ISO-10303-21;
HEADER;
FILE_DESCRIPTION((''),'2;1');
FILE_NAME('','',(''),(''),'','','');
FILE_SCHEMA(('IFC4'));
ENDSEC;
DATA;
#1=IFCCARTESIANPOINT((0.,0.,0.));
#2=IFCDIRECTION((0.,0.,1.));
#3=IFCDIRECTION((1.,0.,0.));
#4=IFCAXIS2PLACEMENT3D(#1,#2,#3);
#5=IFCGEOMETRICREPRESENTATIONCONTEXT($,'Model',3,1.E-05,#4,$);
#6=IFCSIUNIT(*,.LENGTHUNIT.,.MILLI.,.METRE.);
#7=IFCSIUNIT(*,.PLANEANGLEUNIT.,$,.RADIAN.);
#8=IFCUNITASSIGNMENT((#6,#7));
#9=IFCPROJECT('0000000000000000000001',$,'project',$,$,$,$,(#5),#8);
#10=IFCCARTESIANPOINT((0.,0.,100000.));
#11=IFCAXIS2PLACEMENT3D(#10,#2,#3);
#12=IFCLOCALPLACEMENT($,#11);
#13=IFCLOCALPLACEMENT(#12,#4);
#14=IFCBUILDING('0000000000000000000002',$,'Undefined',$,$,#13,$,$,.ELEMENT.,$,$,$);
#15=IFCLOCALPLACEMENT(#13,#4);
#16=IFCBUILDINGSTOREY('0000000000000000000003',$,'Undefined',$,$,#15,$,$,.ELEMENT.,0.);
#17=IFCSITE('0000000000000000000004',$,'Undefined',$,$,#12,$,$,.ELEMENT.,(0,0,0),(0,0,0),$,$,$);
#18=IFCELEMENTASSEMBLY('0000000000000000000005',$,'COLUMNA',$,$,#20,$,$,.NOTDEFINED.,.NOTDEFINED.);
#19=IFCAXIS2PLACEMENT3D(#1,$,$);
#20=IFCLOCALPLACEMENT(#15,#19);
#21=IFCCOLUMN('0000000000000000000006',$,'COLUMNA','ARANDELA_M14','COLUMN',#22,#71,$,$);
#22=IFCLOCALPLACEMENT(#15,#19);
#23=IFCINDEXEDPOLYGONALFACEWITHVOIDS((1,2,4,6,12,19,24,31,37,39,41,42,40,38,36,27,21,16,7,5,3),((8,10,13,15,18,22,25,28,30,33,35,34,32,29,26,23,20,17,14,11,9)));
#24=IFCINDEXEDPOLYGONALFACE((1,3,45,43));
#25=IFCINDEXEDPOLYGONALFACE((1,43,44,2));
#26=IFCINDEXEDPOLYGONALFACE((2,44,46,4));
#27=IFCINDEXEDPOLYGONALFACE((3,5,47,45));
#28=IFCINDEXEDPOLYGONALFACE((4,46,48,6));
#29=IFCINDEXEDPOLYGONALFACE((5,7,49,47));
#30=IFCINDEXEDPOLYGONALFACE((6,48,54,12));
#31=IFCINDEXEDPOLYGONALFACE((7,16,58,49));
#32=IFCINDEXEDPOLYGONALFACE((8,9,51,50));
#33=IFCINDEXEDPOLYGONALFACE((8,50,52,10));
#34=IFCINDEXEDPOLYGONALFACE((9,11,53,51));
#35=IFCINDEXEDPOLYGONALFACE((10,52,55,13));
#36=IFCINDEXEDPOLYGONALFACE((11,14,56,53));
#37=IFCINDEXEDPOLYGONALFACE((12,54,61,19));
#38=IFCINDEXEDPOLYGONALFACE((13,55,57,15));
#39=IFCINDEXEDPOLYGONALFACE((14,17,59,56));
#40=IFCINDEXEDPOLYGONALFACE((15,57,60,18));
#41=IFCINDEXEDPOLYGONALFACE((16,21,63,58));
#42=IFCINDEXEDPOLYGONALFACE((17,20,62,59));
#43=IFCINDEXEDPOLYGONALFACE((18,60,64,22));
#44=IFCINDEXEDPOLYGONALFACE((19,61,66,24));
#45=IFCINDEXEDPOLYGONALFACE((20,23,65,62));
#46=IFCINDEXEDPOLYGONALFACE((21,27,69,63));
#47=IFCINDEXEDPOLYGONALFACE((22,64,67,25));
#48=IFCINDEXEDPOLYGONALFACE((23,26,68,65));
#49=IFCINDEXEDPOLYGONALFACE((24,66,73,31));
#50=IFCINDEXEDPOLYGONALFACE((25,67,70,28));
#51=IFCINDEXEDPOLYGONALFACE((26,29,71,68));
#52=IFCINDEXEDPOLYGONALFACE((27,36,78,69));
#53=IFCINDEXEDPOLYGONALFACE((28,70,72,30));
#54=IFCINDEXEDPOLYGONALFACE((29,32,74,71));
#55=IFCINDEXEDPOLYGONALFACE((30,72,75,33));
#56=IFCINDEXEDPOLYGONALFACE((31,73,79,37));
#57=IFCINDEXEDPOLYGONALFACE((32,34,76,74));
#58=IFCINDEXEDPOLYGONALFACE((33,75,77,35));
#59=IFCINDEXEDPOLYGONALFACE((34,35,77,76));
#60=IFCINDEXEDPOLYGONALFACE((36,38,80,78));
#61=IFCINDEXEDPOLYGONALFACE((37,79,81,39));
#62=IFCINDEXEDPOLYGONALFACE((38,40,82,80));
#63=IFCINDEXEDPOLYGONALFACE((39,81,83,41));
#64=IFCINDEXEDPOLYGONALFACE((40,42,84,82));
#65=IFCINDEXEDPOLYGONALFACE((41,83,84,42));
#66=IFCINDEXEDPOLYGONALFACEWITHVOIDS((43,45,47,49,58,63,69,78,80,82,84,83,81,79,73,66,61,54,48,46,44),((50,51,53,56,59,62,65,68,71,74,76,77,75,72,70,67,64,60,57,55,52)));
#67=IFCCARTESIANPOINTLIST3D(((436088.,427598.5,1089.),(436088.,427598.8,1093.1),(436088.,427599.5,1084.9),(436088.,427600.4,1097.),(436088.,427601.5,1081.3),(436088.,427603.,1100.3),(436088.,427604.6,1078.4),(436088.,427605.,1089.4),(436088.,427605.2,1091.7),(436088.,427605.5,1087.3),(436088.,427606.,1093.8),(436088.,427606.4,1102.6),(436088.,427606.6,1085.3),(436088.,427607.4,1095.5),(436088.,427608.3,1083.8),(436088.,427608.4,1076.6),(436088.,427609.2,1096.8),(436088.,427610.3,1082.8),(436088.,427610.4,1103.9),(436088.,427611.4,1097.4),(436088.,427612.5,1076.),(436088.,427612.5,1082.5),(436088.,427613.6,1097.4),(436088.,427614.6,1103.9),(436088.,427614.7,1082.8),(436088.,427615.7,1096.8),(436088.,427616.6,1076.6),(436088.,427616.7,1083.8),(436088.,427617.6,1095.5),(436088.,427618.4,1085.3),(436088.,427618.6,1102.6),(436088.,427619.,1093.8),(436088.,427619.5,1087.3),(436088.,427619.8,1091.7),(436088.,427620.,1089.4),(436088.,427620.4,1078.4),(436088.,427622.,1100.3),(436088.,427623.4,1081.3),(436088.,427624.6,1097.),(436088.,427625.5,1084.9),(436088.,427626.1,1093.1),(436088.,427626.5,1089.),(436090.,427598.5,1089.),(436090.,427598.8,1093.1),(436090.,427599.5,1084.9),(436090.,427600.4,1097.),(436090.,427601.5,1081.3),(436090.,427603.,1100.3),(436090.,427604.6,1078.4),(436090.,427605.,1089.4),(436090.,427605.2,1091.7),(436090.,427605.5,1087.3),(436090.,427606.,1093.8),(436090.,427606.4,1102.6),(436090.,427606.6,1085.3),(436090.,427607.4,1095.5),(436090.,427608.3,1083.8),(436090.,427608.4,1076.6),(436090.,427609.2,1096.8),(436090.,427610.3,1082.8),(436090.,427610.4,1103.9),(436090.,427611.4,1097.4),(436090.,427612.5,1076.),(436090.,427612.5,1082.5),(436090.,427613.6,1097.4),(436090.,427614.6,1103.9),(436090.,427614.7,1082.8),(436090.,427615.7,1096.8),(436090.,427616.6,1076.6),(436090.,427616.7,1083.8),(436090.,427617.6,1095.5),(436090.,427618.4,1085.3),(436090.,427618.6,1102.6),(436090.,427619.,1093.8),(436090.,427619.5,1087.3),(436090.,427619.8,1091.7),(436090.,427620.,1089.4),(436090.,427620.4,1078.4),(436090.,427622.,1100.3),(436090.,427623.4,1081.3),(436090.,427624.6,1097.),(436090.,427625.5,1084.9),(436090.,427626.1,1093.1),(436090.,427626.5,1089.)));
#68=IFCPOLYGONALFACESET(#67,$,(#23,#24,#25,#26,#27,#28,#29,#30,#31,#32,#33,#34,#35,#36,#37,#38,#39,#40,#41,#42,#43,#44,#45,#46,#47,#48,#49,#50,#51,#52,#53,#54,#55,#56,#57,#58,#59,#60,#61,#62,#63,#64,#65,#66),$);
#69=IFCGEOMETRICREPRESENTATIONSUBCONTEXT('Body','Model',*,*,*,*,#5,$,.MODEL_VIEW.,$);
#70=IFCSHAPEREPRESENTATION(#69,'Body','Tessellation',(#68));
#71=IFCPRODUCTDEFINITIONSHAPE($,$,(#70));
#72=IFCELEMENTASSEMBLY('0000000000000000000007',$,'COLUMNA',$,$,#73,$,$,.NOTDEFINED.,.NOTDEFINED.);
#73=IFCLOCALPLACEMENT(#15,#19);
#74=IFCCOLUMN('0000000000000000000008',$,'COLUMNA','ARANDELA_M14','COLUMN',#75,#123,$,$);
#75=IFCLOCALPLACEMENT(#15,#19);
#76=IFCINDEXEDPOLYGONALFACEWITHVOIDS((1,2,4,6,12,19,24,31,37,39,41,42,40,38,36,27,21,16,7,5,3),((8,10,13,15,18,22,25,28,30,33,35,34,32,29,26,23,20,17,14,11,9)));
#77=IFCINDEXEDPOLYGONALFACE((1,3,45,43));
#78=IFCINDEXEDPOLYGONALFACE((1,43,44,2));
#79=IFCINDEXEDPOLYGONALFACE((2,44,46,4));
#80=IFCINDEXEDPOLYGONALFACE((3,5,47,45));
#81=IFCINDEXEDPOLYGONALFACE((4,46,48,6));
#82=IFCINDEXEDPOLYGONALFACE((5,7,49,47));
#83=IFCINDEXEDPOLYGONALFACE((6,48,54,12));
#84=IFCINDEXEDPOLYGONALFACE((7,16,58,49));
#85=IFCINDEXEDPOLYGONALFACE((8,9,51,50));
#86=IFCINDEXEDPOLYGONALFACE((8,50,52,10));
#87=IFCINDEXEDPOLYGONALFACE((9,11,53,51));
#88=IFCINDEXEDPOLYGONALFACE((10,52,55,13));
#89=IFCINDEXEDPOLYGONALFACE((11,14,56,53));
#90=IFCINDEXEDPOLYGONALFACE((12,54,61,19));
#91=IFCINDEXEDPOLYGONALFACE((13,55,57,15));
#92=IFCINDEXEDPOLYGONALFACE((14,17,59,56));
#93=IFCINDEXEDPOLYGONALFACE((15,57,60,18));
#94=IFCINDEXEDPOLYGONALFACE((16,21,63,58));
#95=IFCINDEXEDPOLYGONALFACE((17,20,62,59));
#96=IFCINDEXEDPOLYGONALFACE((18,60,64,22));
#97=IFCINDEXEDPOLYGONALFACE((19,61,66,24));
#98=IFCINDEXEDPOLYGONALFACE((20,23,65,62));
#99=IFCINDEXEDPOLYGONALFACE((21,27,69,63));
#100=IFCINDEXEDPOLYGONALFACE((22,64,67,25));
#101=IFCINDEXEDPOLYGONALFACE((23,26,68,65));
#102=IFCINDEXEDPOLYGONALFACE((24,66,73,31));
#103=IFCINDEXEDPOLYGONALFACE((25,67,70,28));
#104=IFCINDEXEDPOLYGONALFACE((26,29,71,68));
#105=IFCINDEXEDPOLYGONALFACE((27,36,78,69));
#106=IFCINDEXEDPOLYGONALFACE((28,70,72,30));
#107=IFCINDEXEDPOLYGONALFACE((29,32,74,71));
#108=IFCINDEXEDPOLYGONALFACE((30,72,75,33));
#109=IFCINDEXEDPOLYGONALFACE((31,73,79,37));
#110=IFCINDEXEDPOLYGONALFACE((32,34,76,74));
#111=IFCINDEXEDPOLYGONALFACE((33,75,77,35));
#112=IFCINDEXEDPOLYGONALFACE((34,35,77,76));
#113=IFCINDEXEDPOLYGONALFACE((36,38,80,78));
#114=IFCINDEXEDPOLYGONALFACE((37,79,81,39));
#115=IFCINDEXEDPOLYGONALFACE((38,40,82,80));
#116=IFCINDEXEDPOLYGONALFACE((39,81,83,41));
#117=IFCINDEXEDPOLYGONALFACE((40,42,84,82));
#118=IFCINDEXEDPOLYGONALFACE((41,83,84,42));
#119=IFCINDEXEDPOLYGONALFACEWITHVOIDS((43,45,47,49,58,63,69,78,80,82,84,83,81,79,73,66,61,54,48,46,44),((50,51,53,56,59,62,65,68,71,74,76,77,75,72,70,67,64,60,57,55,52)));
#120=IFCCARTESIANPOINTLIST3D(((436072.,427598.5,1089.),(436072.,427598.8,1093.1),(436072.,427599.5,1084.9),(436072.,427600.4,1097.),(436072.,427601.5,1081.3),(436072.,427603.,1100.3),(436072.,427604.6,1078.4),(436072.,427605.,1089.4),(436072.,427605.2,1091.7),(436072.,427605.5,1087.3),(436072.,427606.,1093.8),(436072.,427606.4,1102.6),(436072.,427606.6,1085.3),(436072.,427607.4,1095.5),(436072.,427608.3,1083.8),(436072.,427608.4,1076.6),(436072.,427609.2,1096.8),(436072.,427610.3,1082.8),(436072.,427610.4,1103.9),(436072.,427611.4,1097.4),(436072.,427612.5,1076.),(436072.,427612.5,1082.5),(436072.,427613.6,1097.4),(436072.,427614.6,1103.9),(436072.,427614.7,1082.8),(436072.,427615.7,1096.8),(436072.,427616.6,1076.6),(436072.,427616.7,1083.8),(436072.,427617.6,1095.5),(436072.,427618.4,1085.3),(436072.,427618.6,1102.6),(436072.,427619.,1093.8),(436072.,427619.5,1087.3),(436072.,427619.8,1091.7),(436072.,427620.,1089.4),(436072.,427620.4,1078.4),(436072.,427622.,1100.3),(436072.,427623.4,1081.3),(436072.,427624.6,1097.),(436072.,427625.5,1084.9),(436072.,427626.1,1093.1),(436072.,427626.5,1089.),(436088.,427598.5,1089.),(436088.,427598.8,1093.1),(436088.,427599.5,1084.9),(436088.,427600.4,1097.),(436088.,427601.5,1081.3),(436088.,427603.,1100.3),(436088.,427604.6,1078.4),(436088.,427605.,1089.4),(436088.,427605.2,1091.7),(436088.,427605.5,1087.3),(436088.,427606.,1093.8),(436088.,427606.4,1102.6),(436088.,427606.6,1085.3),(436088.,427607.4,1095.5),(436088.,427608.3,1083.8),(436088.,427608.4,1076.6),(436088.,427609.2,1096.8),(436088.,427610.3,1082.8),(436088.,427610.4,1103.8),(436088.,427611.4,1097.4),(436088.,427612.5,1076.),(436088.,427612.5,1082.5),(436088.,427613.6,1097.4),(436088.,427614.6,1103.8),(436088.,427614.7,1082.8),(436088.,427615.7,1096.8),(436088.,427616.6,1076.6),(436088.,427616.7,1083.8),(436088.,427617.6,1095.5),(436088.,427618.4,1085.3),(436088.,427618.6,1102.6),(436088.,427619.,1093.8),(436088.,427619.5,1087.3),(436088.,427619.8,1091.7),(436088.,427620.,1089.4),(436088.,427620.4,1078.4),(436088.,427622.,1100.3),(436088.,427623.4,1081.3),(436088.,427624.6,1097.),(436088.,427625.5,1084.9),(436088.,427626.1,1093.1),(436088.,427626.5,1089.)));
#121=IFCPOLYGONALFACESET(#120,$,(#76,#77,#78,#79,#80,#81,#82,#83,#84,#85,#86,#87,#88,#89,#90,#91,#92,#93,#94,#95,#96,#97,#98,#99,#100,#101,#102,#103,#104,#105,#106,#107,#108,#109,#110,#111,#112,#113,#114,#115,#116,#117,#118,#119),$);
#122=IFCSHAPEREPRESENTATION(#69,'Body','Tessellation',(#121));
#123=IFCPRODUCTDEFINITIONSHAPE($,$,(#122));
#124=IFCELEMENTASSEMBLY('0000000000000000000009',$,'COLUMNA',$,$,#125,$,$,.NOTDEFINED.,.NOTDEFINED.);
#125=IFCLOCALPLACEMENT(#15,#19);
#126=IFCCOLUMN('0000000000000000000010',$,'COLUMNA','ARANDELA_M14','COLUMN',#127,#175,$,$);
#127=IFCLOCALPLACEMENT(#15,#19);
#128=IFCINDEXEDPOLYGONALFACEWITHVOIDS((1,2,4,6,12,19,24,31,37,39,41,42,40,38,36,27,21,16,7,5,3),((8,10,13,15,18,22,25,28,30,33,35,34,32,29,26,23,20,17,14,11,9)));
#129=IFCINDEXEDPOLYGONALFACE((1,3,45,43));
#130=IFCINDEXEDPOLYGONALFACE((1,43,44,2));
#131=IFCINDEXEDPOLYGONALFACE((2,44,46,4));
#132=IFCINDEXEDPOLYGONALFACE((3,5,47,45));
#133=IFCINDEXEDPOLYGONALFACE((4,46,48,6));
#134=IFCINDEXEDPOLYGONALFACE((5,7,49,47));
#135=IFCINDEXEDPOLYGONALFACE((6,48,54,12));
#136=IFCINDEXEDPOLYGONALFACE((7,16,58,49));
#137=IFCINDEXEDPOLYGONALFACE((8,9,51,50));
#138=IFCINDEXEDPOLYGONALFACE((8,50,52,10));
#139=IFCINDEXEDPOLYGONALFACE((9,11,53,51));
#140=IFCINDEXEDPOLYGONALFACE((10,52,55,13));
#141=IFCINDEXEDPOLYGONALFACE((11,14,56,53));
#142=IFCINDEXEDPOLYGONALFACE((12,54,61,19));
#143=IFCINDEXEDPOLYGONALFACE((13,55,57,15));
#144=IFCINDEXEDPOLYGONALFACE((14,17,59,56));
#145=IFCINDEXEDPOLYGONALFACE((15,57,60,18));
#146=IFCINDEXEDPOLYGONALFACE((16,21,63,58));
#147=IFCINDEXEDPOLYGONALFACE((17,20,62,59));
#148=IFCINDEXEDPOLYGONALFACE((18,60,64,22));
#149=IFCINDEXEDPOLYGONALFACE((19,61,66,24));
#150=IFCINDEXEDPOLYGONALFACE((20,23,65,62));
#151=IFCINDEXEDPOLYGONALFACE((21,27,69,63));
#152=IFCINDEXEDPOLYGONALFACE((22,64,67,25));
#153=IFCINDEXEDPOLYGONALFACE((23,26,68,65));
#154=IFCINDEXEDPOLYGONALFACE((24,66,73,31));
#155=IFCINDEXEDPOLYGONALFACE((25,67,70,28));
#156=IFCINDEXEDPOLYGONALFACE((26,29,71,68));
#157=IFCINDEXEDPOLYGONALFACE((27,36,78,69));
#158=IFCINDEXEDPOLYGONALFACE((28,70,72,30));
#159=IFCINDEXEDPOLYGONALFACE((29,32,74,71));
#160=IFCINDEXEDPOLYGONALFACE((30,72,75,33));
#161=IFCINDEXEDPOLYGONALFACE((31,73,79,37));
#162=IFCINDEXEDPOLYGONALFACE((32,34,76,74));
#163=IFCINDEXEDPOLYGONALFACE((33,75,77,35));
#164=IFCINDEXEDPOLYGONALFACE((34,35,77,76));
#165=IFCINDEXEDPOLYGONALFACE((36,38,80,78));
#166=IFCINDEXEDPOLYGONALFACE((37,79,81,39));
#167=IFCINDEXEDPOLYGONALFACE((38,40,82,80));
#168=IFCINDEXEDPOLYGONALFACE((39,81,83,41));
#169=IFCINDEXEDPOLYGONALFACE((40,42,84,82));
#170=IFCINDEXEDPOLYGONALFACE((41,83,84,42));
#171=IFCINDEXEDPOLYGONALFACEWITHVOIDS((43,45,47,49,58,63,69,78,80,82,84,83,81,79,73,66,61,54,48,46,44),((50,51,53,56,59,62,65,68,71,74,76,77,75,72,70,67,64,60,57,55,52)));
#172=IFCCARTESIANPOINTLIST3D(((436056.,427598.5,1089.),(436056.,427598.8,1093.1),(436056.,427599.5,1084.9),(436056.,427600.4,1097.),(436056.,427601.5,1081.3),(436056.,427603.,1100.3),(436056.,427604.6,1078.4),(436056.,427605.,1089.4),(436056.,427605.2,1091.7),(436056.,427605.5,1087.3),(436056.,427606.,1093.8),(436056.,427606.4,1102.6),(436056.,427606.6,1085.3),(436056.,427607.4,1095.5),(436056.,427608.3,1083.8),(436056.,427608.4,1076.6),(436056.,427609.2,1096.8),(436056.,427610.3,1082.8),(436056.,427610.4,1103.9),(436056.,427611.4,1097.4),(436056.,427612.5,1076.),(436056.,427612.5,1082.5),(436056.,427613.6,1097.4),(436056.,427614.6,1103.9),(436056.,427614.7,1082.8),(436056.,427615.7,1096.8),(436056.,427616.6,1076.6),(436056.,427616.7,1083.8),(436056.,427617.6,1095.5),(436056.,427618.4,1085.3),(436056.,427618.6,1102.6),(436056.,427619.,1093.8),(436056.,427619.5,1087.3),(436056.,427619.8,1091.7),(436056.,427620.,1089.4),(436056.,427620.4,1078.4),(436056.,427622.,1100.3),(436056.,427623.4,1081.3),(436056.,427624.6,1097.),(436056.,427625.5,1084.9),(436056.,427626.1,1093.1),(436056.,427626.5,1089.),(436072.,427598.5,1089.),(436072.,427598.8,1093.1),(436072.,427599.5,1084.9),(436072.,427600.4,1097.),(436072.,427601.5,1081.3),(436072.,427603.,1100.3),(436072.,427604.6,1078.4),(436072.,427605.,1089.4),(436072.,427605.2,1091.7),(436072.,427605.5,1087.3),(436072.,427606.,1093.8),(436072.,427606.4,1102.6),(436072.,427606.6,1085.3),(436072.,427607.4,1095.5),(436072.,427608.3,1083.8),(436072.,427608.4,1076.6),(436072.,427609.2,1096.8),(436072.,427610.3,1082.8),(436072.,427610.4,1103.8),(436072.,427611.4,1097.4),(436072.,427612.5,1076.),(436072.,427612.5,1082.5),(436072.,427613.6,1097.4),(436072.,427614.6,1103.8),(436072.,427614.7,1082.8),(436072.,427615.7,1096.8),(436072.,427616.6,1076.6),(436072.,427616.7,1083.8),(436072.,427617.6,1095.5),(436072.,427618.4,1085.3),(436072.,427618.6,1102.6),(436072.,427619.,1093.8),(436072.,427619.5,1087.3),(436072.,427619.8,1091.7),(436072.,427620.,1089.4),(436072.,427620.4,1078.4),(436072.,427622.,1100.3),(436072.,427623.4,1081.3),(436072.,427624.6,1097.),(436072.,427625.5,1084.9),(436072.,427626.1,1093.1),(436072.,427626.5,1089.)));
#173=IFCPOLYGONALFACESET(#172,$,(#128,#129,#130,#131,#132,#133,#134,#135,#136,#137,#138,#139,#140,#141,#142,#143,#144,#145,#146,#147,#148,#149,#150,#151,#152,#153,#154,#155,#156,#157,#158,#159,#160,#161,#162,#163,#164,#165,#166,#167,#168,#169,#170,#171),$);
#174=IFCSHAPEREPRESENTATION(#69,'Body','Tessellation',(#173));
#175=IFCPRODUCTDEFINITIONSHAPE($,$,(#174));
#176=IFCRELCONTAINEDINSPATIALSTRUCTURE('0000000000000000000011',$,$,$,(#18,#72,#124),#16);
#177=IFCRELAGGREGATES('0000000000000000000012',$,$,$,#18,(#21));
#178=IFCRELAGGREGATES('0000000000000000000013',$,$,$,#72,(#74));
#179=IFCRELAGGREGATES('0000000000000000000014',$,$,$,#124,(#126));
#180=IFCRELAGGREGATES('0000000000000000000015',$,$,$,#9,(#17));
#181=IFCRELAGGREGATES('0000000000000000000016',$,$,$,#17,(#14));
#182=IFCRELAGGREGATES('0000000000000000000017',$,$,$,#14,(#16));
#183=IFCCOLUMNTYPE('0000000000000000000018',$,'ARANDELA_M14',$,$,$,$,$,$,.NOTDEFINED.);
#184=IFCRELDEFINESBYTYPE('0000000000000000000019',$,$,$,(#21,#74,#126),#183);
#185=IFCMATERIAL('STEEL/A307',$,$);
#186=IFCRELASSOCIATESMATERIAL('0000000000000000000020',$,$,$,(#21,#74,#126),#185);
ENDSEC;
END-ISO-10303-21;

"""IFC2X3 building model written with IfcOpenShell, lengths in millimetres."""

from ifc_helpers import new_model, si_unit, frame, origin_with_axes, origin_2d_with_axis, place, context, subcontext, project, spatial, hollow_circle, extrude, material, type_object, element, aggregate, save


model = new_model("IFC2X3")

# Units and contexts
model_context = context("Model", 3, precision=1e-05, world=origin_with_axes())
body_context = subcontext(model_context, "Body", "Model", "MODEL_VIEW")
ifc_project = project(units=[si_unit("LENGTHUNIT", "METRE", prefix="MILLI"), si_unit("PLANEANGLEUNIT", "RADIAN")], contexts=[model_context])

# Site, building, storey
site_placement = place(None, frame((0.0, 0.0, 100000.0), z_axis=(0.0, 0.0, 1.0), x_axis=(1.0, 0.0, 0.0)))
site = spatial("IfcSite", under=ifc_project, at=site_placement, Name="Undefined", CompositionType="ELEMENT", RefLatitude=(0, 0, 0), RefLongitude=(0, 0, 0))
building_placement = place(site_placement, origin_with_axes())
building = spatial("IfcBuilding", under=site, at=building_placement, Name="Undefined", CompositionType="ELEMENT")
storey_placement = place(building_placement, origin_with_axes())
storey = spatial("IfcBuildingStorey", under=building, at=storey_placement, Name="Undefined", CompositionType="ELEMENT", Elevation=0.0)

# Element assemblies, columns
ifc_material_1 = material(Name="STEEL/A307")
column_type_1 = type_object("IfcColumnType", Name="ARANDELA_M14", PredefinedType="NOTDEFINED")
assembly_1_placement = place(storey_placement, origin_with_axes())
assembly_1 = element("IfcElementAssembly", 1, at=assembly_1_placement, inside=storey, Name="COLUMNA", AssemblyPlace="NOTDEFINED", PredefinedType="NOTDEFINED")
column_1_placement = place(assembly_1_placement, frame((436090.0, 427612.5, 1090.0), z_axis=(-1.0, 0.0, 0.000285), x_axis=(0.0, 1.0, 0.0)))
column_1 = element("IfcColumn", 2, at=column_1_placement, type_object=column_type_1, material=ifc_material_1, Name="COLUMNA", Description="ARANDELA_M14", ObjectType="COLUMN", context=body_context, shape_type="SweptSolid", body=[
    extrude(hollow_circle(Radius=14.0, WallThickness=6.5, at=origin_2d_with_axis()), frame((0.0, 0.0, 2.0), z_axis=(0.0, 0.0, -1.0), x_axis=(0.0, 1.0, 0.0)), (0.0, 0.0, 1.0), 2.0),
])
aggregate(assembly_1, [column_1])
assembly_2_placement = place(storey_placement, origin_with_axes())
assembly_2 = element("IfcElementAssembly", 3, at=assembly_2_placement, inside=storey, Name="COLUMNA", AssemblyPlace="NOTDEFINED", PredefinedType="NOTDEFINED")
column_2_placement = place(assembly_2_placement, frame((436088.0, 427612.5, 1090.0), z_axis=(-1.0, 0.0, 0.000285), x_axis=(0.0, 1.0, 0.0)))
column_2 = element("IfcColumn", 4, at=column_2_placement, type_object=column_type_1, material=ifc_material_1, Name="COLUMNA", Description="ARANDELA_M14", ObjectType="COLUMN", context=body_context, shape_type="SweptSolid", body=[
    extrude(hollow_circle(Radius=14.0, WallThickness=6.5, at=origin_2d_with_axis()), frame((0.0, 0.0, 16.0), z_axis=(0.0, 0.0, -1.0), x_axis=(0.0, 1.0, 0.0)), (0.0, 0.0, 1.0), 16.0),
])
aggregate(assembly_2, [column_2])
assembly_3_placement = place(storey_placement, origin_with_axes())
assembly_3 = element("IfcElementAssembly", 5, at=assembly_3_placement, inside=storey, Name="COLUMNA", AssemblyPlace="NOTDEFINED", PredefinedType="NOTDEFINED")
column_3_placement = place(assembly_3_placement, frame((436072.0, 427612.5, 1090.0), z_axis=(-1.0, 0.0, 0.000285), x_axis=(0.0, 1.0, 0.0)))
column_3 = element("IfcColumn", 6, at=column_3_placement, type_object=column_type_1, material=ifc_material_1, Name="COLUMNA", Description="ARANDELA_M14", ObjectType="COLUMN", context=body_context, shape_type="SweptSolid", body=[
    extrude(hollow_circle(Radius=14.0, WallThickness=6.5, at=origin_2d_with_axis()), frame((0.0, 0.0, 16.0), z_axis=(0.0, 0.0, -1.0), x_axis=(0.0, 1.0, 0.0)), (0.0, 0.0, 1.0), 16.0),
])
aggregate(assembly_3, [column_3])

save(model, "model.ifc")
